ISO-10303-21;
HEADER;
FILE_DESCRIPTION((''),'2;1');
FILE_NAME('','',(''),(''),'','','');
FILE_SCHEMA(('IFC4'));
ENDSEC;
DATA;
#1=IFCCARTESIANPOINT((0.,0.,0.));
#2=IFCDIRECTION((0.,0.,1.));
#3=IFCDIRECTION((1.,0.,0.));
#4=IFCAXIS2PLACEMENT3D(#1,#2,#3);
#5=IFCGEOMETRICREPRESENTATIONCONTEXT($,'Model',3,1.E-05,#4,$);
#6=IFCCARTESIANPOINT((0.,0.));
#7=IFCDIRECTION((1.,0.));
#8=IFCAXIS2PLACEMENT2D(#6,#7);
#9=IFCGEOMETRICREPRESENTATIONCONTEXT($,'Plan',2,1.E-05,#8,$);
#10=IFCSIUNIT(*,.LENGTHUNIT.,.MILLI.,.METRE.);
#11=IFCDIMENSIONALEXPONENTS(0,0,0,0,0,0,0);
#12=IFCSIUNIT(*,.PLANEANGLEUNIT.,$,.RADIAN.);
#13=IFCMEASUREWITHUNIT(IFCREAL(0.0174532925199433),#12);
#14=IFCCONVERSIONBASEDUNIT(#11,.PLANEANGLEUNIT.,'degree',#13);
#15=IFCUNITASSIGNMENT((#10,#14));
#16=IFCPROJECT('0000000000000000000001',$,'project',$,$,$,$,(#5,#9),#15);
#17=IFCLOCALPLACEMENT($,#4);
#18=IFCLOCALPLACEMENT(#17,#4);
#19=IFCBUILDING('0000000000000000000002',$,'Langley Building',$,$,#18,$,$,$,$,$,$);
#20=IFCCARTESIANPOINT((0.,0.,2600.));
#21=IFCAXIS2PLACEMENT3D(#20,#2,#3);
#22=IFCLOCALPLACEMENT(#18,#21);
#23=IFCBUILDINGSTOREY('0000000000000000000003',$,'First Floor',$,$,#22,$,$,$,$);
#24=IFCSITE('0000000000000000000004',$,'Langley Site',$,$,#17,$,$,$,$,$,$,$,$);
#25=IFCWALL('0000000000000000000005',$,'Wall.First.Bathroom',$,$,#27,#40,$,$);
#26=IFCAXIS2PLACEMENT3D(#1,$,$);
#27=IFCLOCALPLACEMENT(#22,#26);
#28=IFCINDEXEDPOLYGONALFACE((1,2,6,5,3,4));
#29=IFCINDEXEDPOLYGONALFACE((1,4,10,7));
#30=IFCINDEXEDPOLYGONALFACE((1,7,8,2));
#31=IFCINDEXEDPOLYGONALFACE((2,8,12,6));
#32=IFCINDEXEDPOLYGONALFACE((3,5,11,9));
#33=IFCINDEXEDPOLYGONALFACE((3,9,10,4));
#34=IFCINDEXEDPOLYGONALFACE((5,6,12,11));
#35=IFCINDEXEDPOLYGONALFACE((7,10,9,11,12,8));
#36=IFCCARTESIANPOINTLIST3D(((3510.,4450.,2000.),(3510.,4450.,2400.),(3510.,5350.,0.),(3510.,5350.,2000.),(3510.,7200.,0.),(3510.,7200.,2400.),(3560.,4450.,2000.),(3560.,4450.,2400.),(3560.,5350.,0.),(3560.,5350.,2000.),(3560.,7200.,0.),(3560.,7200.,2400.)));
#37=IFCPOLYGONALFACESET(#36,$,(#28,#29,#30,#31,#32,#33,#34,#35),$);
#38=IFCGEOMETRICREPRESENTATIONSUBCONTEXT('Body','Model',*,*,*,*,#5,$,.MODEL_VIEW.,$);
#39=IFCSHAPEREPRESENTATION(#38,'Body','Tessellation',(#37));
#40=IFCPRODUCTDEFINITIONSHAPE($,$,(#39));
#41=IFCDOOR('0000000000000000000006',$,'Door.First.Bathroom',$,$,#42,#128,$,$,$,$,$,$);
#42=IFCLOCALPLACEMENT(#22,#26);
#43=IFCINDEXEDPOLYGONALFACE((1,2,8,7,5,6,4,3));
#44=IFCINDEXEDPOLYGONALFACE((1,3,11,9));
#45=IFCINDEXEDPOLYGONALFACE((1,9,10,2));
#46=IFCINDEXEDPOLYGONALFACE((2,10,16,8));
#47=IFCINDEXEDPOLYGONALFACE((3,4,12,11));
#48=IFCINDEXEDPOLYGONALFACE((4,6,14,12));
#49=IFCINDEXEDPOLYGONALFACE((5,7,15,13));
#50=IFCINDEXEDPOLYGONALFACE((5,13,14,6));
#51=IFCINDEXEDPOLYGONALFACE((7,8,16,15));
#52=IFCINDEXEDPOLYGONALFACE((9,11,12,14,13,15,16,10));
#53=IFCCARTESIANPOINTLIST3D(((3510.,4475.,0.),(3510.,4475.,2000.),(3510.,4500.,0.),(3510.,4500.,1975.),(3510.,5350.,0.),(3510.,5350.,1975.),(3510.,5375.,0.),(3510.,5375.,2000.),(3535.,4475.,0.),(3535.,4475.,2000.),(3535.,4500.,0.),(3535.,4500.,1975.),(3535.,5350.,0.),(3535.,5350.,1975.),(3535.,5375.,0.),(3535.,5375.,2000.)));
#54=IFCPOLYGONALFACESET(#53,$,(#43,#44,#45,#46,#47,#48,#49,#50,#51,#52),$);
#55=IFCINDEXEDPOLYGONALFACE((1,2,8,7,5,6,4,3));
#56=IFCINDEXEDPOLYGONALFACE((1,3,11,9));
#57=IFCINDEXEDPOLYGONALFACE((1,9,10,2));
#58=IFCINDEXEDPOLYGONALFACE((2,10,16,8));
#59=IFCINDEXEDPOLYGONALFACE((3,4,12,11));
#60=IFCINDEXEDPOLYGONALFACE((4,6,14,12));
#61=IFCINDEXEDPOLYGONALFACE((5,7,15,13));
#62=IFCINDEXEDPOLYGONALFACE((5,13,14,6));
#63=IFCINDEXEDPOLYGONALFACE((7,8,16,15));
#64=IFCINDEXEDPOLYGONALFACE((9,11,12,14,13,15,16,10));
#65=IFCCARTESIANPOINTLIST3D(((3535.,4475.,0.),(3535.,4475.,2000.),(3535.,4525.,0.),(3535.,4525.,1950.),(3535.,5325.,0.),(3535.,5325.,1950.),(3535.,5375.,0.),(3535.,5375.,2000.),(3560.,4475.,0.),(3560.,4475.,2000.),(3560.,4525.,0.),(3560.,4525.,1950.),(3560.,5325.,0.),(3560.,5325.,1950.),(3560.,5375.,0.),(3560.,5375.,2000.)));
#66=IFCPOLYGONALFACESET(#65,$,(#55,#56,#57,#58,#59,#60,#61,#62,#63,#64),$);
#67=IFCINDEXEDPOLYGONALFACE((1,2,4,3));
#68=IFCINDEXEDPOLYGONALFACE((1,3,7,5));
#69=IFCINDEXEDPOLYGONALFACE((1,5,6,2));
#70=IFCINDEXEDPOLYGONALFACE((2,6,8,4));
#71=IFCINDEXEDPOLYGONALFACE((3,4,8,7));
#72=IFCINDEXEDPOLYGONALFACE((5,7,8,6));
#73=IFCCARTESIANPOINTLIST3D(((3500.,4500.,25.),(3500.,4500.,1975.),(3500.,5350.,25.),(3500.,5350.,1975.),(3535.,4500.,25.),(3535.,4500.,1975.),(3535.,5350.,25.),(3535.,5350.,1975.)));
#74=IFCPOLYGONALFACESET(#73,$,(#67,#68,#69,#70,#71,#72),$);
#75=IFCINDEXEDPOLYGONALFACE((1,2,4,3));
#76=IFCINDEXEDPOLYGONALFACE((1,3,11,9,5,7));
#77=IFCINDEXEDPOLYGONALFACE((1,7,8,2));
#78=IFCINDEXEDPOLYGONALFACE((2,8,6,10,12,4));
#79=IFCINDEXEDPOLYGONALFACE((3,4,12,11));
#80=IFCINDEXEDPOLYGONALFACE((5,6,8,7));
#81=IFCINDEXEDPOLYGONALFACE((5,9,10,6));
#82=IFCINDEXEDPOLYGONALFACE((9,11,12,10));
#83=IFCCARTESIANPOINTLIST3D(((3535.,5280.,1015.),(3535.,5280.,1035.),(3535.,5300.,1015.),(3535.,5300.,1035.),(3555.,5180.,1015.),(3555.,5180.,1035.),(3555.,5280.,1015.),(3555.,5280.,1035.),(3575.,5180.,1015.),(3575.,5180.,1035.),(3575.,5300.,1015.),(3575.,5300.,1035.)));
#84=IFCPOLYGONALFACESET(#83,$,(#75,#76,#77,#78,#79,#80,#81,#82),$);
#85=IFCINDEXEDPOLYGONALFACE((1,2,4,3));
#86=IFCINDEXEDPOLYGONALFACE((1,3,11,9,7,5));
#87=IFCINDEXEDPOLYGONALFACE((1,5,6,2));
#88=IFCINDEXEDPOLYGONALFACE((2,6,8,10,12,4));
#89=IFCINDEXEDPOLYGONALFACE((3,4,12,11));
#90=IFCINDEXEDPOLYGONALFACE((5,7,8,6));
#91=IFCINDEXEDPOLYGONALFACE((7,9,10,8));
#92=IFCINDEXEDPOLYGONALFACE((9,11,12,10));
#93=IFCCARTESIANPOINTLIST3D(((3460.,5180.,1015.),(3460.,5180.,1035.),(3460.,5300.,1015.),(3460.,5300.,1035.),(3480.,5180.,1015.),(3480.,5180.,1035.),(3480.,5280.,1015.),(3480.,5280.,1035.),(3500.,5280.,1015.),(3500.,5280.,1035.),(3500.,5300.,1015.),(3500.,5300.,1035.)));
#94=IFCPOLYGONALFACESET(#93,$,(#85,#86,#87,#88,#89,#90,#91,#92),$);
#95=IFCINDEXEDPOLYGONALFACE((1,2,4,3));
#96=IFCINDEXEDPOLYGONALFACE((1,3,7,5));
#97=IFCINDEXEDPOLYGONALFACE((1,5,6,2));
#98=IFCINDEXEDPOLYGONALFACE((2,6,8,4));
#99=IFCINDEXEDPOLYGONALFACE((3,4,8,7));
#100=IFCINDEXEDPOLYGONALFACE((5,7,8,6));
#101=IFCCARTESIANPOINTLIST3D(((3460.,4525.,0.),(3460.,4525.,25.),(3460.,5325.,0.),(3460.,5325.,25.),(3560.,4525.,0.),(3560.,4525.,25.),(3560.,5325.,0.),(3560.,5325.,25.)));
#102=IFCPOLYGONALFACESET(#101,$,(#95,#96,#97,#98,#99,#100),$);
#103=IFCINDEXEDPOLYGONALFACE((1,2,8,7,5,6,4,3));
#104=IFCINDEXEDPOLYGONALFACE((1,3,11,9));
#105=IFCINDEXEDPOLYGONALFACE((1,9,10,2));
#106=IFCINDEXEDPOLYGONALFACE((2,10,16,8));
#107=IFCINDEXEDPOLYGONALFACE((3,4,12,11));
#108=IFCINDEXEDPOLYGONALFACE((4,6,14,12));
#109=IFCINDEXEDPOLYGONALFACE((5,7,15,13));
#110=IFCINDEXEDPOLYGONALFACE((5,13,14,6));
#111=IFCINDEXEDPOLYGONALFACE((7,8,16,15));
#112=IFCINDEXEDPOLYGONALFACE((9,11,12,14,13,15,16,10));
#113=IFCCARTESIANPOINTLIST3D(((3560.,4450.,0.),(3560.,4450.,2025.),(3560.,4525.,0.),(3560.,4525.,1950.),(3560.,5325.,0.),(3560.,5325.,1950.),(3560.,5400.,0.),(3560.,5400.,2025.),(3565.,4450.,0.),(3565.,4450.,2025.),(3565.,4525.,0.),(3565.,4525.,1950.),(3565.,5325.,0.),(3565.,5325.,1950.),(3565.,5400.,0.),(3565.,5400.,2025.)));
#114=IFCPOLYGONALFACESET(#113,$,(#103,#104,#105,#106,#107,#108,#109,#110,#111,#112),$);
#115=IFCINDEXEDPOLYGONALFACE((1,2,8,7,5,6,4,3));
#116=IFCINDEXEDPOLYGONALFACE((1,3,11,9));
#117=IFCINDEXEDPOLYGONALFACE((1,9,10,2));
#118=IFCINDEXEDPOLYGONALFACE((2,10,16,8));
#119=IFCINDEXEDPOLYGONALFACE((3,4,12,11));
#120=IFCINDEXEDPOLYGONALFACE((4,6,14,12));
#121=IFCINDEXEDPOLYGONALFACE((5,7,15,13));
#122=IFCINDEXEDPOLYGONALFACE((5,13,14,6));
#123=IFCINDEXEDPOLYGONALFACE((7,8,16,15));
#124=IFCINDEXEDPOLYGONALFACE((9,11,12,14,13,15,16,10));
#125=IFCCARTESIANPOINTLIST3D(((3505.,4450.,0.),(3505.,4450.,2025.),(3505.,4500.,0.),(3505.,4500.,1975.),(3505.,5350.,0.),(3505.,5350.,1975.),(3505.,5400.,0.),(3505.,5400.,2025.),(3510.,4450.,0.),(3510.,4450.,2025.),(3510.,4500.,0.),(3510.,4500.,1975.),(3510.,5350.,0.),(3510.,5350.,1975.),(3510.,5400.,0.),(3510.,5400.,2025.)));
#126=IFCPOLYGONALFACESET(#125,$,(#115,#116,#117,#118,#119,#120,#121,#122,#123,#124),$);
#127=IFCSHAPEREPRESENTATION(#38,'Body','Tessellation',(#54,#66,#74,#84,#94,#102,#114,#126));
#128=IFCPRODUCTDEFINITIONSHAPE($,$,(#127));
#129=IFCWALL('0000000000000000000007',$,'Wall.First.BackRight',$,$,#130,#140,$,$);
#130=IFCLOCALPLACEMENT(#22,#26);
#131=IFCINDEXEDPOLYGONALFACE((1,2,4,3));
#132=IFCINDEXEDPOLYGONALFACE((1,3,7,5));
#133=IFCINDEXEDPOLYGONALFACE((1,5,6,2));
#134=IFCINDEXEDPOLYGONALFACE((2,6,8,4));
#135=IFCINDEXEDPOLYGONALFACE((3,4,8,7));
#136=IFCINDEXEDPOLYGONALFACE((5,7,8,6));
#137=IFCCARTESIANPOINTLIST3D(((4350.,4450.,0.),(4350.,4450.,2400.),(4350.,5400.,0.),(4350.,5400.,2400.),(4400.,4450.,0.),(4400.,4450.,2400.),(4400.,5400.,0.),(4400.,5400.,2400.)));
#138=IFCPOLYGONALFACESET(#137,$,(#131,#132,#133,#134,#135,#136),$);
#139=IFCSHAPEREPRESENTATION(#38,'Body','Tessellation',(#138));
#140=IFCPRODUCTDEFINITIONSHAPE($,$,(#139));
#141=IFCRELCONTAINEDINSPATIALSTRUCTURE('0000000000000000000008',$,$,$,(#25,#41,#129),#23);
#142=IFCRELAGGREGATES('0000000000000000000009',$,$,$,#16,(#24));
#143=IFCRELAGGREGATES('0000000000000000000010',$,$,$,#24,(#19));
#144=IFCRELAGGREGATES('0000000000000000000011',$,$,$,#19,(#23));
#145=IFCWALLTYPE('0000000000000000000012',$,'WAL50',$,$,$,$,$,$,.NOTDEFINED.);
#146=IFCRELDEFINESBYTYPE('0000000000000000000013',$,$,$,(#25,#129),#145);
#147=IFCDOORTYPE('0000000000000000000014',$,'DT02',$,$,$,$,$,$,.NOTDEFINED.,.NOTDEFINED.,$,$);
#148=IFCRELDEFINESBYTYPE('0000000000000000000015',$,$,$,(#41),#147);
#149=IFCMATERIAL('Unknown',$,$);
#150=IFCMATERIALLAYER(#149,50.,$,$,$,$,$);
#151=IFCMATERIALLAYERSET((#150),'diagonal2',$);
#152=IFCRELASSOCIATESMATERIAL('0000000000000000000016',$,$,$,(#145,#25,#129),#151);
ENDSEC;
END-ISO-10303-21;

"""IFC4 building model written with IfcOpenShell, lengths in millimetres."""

from ifc_helpers import new_model, entity, si_unit, converted_unit, frame, origin_with_axes, origin_2d_with_axis, place, context, subcontext, project, spatial, line, indexed_curve, outline, extrude, shape, source, transform, mapped, material, layer, layer_set, layer_usage, type_object, type_shapes, element, fill, save


model = new_model("IFC4")

# Units and contexts
model_context = context("Model", 3, precision=1e-05, world=origin_with_axes())
plan_context = context("Plan", 2, precision=1e-05, world=origin_2d_with_axis())
body_context_1 = subcontext(model_context, "Body", "Model", "MODEL_VIEW")
body_context_2 = subcontext(plan_context, "Body", "Plan", "PLAN_VIEW")
ifc_project = project(units=[si_unit("LENGTHUNIT", "METRE", prefix="MILLI"), converted_unit("PLANEANGLEUNIT", "degree", entity("IfcReal", 0.0174532925199433), si_unit("PLANEANGLEUNIT", "RADIAN"), dimensions=[0, 0, 0, 0, 0, 0, 0])], contexts=[model_context, plan_context])

# Site, building, storey
site_placement = place(None, origin_with_axes())
site = spatial("IfcSite", under=ifc_project, at=site_placement, Name="Langley Site")
building_placement = place(site_placement, origin_with_axes())
building = spatial("IfcBuilding", under=site, at=building_placement, Name="Langley Building")
storey_placement = place(building_placement, frame((0.0, 0.0, 2600.0), z_axis=(0.0, 0.0, 1.0), x_axis=(1.0, 0.0, 0.0)))
storey = spatial("IfcBuildingStorey", under=building, at=storey_placement, Name="First Floor")

# Wall, opening, door
ifc_material = material(Name="Unknown")
ifc_layer_1 = layer(ifc_material, 50.0)
ifc_layer_set_1 = layer_set([ifc_layer_1], Name="diagonal2")
wall_type_1 = type_object("IfcWallType", Name="WAL50", PredefinedType="NOTDEFINED", material=ifc_layer_set_1)
ifc_layer_usage_1 = layer_usage(ifc_layer_set_1, "AXIS2", "POSITIVE", 0.0)
wall_1_placement = place(storey_placement, frame((3560.0, 4450.0, 0.0), z_axis=(0.0, 0.0, 1.0), x_axis=(0.0, 1.0, 0.0)))
wall_1 = element("IfcWall", 1, at=wall_1_placement, inside=storey, type_object=wall_type_1, material=ifc_layer_usage_1, Name="Wall.First.Bathroom", context=body_context_1, shape_type="SweptSolid", body=[
    extrude(outline(indexed_curve([(0.0, 0.0), (0.0, 50.0), (2750.0, 50.0), (2750.0, 0.0)], segments=[line(1, 2, 3, 4, 1)])), origin_with_axes(), (0.0, 0.0, 1.0), 2400.0),
])
shared_shape_1 = source(origin_with_axes(), body_context_1, "Body", "SweptSolid", [
    extrude(outline(indexed_curve([(0.0, 0.0), (900.0, 0.0), (900.0, 2000.0), (0.0, 2000.0)], segments=[line(1, 2, 3, 4, 1)])), frame((0.0, -600.0, 0.0), z_axis=(0.0, -1.0, 0.0), x_axis=(1.0, 0.0, 0.0)), (0.0, 0.0, -1.0), 1200.0),
])
opening_1_placement = place(wall_1_placement, origin_with_axes())
opening_1 = element("IfcOpeningElement", 2, at=opening_1_placement, cuts=wall_1, PredefinedType="OPENING", context=body_context_1, shape_type="MappedRepresentation", body=[
    mapped(shared_shape_1, transform((0.0, 0.0, 0.0), x_axis=(1.0, 0.0, 0.0), y_axis=(0.0, 1.0, 0.0), z_axis=(0.0, 0.0, 1.0), scale=1.0)),
])
door_type_1 = type_object("IfcDoorType", Name="DT02", OperationType="NOTDEFINED", PredefinedType="NOTDEFINED")
shared_shape_2 = source(origin_with_axes(), body_context_1, "Body", "SweptSolid", [
    extrude(outline(indexed_curve([(0.0, 0.0), (0.0, 2000.0), (900.0, 2000.0), (900.0, 0.0), (875.0, 0.0), (875.0, 1975.0), (25.0, 1975.0), (25.0, 0.0)], segments=[line(1, 2, 3, 4, 5, 6, 7, 8, 1)])), frame((0.0, 25.0, 0.0), z_axis=(0.0, -1.0, 0.0), x_axis=(1.0, 0.0, 0.0)), (0.0, 0.0, -1.0), 25.0),
    extrude(outline(indexed_curve([(0.0, 0.0), (0.0, 2000.0), (900.0, 2000.0), (900.0, 0.0), (850.0, 0.0), (850.0, 1950.0), (50.0, 1950.0), (50.0, 0.0)], segments=[line(1, 2, 3, 4, 5, 6, 7, 8, 1)])), frame((0.0, 0.0, 0.0), z_axis=(0.0, -1.0, 0.0), x_axis=(1.0, 0.0, 0.0)), (0.0, 0.0, -1.0), 25.0),
    extrude(outline(indexed_curve([(0.0, 0.0), (850.0, 0.0), (850.0, 35.0), (0.0, 35.0)], segments=[line(1, 2, 3, 4, 1)])), frame((25.0, 25.0, 25.0), z_axis=(0.0, 0.0, 1.0), x_axis=(1.0, 0.0, 0.0)), (0.0, 0.0, 1.0), 1950.0),
    extrude(outline(indexed_curve([(0.0, 0.0), (0.0, -40.0), (-120.0, -40.0), (-120.0, -20.0), (-20.0, -20.0), (-20.0, 0.0)], segments=[line(1, 2, 3, 4, 5, 6, 1)])), frame((825.0, 25.0, 1015.0), z_axis=(0.0, 0.0, 1.0), x_axis=(1.0, 0.0, 0.0)), (0.0, 0.0, 1.0), 20.0),
    extrude(outline(indexed_curve([(0.0, 0.0), (0.0, 40.0), (-120.0, 40.0), (-120.0, 20.0), (-20.0, 20.0), (-20.0, 0.0)], segments=[line(1, 2, 3, 4, 5, 6, 1)])), frame((825.0, 60.0, 1015.0), z_axis=(0.0, 0.0, 1.0), x_axis=(1.0, 0.0, 0.0)), (0.0, 0.0, 1.0), 20.0),
    extrude(outline(indexed_curve([(0.0, 0.0), (800.0, 0.0), (800.0, 100.0), (0.0, 100.0)], segments=[line(1, 2, 3, 4, 1)])), frame((50.0, 0.0, 0.0), z_axis=(0.0, 0.0, 1.0), x_axis=(1.0, 0.0, 0.0)), (0.0, 0.0, 1.0), 25.0),
    extrude(outline(indexed_curve([(0.0, 0.0), (0.0, 2025.0), (950.0, 2025.0), (950.0, 0.0), (875.0, 0.0), (875.0, 1950.0), (75.0, 1950.0), (75.0, 0.0)], segments=[line(1, 2, 3, 4, 5, 6, 7, 8, 1)])), frame((-25.0, -5.0, 0.0), z_axis=(0.0, -1.0, 0.0), x_axis=(1.0, 0.0, 0.0)), (0.0, 0.0, -1.0), 5.0),
    extrude(outline(indexed_curve([(0.0, 0.0), (0.0, 2025.0), (950.0, 2025.0), (950.0, 0.0), (900.0, 0.0), (900.0, 1975.0), (50.0, 1975.0), (50.0, 0.0)], segments=[line(1, 2, 3, 4, 5, 6, 7, 8, 1)])), frame((-25.0, 50.0, 0.0), z_axis=(0.0, -1.0, 0.0), x_axis=(1.0, 0.0, 0.0)), (0.0, 0.0, -1.0), 5.0),
])
shared_shape_3 = source(origin_with_axes(), body_context_2, "Body", "Curve2D", [
    entity("IfcIndexedPolyCurve", entity("IfcCartesianPointList2D", [[0.0, 0.0], [0.0, 50.0], [25.0, 50.0], [25.0, 25.0], [50.0, 25.0], [50.0, 0.0]]), [entity("IfcLineIndex", [1, 2, 3, 4, 5, 6, 1])]),
    entity("IfcIndexedPolyCurve", entity("IfcCartesianPointList2D", [[900.0, 0.0], [900.0, 50.0], [875.0, 50.0], [875.0, 25.0], [850.0, 25.0], [850.0, 0.0]]), [entity("IfcLineIndex", [1, 2, 3, 4, 5, 6, 1])]),
    entity("IfcTrimmedCurve", entity("IfcEllipse", entity("IfcAxis2Placement2D", entity("IfcCartesianPoint", [60.0, 50.0]), entity("IfcDirection", [1.0, 0.0])), 815.0, 850.0), [entity("IfcCartesianPoint", [875.0, 50.0])], [entity("IfcCartesianPoint", [60.0, 900.0])], True, "CARTESIAN"),
    entity("IfcIndexedPolyCurve", entity("IfcCartesianPointList2D", [[25.0, 50.0], [60.0, 50.0], [60.0, 900.0], [25.0, 900.0]]), [entity("IfcLineIndex", [1, 2, 3, 4, 1])]),
])
type_shapes(door_type_1, [shared_shape_2, shared_shape_3])
door_1_placement = place(opening_1_placement, frame((25.0, 0.0, 0.0), z_axis=(0.0, 0.0, 1.0), x_axis=(1.0, 0.0, 0.0)))
door_1 = element("IfcDoor", 3, at=door_1_placement, inside=storey, type_object=door_type_1, Name="Door.First.Bathroom", shapes=[
    shape(body_context_1, "Body", "MappedRepresentation", [mapped(shared_shape_2, transform((0.0, 0.0, 0.0), x_axis=(1.0, 0.0, 0.0), y_axis=(0.0, 1.0, 0.0), z_axis=(0.0, 0.0, 1.0), scale=1.0))]),
    shape(body_context_2, "Body", "MappedRepresentation", [mapped(shared_shape_3, transform((0.0, 0.0, 0.0), x_axis=(1.0, 0.0, 0.0), y_axis=(0.0, 1.0, 0.0), z_axis=(0.0, 0.0, 1.0), scale=1.0))]),
])
fill(opening_1, door_1)

# Wall
ifc_layer_usage_2 = layer_usage(ifc_layer_set_1, "AXIS2", "POSITIVE", 0.0)
wall_2_placement = place(storey_placement, frame((4400.0, 4450.0, 0.0), z_axis=(0.0, 0.0, 1.0), x_axis=(0.0, 1.0, 0.0)))
element("IfcWall", 4, at=wall_2_placement, inside=storey, type_object=wall_type_1, material=ifc_layer_usage_2, Name="Wall.First.BackRight", context=body_context_1, shape_type="SweptSolid", body=[
    extrude(outline(indexed_curve([(0.0, 0.0), (0.0, 50.0), (950.0, 50.0), (950.0, 0.0)], segments=[line(1, 2, 3, 4, 1)])), origin_with_axes(), (0.0, 0.0, 1.0), 2400.0),
])

save(model, "model.ifc")
